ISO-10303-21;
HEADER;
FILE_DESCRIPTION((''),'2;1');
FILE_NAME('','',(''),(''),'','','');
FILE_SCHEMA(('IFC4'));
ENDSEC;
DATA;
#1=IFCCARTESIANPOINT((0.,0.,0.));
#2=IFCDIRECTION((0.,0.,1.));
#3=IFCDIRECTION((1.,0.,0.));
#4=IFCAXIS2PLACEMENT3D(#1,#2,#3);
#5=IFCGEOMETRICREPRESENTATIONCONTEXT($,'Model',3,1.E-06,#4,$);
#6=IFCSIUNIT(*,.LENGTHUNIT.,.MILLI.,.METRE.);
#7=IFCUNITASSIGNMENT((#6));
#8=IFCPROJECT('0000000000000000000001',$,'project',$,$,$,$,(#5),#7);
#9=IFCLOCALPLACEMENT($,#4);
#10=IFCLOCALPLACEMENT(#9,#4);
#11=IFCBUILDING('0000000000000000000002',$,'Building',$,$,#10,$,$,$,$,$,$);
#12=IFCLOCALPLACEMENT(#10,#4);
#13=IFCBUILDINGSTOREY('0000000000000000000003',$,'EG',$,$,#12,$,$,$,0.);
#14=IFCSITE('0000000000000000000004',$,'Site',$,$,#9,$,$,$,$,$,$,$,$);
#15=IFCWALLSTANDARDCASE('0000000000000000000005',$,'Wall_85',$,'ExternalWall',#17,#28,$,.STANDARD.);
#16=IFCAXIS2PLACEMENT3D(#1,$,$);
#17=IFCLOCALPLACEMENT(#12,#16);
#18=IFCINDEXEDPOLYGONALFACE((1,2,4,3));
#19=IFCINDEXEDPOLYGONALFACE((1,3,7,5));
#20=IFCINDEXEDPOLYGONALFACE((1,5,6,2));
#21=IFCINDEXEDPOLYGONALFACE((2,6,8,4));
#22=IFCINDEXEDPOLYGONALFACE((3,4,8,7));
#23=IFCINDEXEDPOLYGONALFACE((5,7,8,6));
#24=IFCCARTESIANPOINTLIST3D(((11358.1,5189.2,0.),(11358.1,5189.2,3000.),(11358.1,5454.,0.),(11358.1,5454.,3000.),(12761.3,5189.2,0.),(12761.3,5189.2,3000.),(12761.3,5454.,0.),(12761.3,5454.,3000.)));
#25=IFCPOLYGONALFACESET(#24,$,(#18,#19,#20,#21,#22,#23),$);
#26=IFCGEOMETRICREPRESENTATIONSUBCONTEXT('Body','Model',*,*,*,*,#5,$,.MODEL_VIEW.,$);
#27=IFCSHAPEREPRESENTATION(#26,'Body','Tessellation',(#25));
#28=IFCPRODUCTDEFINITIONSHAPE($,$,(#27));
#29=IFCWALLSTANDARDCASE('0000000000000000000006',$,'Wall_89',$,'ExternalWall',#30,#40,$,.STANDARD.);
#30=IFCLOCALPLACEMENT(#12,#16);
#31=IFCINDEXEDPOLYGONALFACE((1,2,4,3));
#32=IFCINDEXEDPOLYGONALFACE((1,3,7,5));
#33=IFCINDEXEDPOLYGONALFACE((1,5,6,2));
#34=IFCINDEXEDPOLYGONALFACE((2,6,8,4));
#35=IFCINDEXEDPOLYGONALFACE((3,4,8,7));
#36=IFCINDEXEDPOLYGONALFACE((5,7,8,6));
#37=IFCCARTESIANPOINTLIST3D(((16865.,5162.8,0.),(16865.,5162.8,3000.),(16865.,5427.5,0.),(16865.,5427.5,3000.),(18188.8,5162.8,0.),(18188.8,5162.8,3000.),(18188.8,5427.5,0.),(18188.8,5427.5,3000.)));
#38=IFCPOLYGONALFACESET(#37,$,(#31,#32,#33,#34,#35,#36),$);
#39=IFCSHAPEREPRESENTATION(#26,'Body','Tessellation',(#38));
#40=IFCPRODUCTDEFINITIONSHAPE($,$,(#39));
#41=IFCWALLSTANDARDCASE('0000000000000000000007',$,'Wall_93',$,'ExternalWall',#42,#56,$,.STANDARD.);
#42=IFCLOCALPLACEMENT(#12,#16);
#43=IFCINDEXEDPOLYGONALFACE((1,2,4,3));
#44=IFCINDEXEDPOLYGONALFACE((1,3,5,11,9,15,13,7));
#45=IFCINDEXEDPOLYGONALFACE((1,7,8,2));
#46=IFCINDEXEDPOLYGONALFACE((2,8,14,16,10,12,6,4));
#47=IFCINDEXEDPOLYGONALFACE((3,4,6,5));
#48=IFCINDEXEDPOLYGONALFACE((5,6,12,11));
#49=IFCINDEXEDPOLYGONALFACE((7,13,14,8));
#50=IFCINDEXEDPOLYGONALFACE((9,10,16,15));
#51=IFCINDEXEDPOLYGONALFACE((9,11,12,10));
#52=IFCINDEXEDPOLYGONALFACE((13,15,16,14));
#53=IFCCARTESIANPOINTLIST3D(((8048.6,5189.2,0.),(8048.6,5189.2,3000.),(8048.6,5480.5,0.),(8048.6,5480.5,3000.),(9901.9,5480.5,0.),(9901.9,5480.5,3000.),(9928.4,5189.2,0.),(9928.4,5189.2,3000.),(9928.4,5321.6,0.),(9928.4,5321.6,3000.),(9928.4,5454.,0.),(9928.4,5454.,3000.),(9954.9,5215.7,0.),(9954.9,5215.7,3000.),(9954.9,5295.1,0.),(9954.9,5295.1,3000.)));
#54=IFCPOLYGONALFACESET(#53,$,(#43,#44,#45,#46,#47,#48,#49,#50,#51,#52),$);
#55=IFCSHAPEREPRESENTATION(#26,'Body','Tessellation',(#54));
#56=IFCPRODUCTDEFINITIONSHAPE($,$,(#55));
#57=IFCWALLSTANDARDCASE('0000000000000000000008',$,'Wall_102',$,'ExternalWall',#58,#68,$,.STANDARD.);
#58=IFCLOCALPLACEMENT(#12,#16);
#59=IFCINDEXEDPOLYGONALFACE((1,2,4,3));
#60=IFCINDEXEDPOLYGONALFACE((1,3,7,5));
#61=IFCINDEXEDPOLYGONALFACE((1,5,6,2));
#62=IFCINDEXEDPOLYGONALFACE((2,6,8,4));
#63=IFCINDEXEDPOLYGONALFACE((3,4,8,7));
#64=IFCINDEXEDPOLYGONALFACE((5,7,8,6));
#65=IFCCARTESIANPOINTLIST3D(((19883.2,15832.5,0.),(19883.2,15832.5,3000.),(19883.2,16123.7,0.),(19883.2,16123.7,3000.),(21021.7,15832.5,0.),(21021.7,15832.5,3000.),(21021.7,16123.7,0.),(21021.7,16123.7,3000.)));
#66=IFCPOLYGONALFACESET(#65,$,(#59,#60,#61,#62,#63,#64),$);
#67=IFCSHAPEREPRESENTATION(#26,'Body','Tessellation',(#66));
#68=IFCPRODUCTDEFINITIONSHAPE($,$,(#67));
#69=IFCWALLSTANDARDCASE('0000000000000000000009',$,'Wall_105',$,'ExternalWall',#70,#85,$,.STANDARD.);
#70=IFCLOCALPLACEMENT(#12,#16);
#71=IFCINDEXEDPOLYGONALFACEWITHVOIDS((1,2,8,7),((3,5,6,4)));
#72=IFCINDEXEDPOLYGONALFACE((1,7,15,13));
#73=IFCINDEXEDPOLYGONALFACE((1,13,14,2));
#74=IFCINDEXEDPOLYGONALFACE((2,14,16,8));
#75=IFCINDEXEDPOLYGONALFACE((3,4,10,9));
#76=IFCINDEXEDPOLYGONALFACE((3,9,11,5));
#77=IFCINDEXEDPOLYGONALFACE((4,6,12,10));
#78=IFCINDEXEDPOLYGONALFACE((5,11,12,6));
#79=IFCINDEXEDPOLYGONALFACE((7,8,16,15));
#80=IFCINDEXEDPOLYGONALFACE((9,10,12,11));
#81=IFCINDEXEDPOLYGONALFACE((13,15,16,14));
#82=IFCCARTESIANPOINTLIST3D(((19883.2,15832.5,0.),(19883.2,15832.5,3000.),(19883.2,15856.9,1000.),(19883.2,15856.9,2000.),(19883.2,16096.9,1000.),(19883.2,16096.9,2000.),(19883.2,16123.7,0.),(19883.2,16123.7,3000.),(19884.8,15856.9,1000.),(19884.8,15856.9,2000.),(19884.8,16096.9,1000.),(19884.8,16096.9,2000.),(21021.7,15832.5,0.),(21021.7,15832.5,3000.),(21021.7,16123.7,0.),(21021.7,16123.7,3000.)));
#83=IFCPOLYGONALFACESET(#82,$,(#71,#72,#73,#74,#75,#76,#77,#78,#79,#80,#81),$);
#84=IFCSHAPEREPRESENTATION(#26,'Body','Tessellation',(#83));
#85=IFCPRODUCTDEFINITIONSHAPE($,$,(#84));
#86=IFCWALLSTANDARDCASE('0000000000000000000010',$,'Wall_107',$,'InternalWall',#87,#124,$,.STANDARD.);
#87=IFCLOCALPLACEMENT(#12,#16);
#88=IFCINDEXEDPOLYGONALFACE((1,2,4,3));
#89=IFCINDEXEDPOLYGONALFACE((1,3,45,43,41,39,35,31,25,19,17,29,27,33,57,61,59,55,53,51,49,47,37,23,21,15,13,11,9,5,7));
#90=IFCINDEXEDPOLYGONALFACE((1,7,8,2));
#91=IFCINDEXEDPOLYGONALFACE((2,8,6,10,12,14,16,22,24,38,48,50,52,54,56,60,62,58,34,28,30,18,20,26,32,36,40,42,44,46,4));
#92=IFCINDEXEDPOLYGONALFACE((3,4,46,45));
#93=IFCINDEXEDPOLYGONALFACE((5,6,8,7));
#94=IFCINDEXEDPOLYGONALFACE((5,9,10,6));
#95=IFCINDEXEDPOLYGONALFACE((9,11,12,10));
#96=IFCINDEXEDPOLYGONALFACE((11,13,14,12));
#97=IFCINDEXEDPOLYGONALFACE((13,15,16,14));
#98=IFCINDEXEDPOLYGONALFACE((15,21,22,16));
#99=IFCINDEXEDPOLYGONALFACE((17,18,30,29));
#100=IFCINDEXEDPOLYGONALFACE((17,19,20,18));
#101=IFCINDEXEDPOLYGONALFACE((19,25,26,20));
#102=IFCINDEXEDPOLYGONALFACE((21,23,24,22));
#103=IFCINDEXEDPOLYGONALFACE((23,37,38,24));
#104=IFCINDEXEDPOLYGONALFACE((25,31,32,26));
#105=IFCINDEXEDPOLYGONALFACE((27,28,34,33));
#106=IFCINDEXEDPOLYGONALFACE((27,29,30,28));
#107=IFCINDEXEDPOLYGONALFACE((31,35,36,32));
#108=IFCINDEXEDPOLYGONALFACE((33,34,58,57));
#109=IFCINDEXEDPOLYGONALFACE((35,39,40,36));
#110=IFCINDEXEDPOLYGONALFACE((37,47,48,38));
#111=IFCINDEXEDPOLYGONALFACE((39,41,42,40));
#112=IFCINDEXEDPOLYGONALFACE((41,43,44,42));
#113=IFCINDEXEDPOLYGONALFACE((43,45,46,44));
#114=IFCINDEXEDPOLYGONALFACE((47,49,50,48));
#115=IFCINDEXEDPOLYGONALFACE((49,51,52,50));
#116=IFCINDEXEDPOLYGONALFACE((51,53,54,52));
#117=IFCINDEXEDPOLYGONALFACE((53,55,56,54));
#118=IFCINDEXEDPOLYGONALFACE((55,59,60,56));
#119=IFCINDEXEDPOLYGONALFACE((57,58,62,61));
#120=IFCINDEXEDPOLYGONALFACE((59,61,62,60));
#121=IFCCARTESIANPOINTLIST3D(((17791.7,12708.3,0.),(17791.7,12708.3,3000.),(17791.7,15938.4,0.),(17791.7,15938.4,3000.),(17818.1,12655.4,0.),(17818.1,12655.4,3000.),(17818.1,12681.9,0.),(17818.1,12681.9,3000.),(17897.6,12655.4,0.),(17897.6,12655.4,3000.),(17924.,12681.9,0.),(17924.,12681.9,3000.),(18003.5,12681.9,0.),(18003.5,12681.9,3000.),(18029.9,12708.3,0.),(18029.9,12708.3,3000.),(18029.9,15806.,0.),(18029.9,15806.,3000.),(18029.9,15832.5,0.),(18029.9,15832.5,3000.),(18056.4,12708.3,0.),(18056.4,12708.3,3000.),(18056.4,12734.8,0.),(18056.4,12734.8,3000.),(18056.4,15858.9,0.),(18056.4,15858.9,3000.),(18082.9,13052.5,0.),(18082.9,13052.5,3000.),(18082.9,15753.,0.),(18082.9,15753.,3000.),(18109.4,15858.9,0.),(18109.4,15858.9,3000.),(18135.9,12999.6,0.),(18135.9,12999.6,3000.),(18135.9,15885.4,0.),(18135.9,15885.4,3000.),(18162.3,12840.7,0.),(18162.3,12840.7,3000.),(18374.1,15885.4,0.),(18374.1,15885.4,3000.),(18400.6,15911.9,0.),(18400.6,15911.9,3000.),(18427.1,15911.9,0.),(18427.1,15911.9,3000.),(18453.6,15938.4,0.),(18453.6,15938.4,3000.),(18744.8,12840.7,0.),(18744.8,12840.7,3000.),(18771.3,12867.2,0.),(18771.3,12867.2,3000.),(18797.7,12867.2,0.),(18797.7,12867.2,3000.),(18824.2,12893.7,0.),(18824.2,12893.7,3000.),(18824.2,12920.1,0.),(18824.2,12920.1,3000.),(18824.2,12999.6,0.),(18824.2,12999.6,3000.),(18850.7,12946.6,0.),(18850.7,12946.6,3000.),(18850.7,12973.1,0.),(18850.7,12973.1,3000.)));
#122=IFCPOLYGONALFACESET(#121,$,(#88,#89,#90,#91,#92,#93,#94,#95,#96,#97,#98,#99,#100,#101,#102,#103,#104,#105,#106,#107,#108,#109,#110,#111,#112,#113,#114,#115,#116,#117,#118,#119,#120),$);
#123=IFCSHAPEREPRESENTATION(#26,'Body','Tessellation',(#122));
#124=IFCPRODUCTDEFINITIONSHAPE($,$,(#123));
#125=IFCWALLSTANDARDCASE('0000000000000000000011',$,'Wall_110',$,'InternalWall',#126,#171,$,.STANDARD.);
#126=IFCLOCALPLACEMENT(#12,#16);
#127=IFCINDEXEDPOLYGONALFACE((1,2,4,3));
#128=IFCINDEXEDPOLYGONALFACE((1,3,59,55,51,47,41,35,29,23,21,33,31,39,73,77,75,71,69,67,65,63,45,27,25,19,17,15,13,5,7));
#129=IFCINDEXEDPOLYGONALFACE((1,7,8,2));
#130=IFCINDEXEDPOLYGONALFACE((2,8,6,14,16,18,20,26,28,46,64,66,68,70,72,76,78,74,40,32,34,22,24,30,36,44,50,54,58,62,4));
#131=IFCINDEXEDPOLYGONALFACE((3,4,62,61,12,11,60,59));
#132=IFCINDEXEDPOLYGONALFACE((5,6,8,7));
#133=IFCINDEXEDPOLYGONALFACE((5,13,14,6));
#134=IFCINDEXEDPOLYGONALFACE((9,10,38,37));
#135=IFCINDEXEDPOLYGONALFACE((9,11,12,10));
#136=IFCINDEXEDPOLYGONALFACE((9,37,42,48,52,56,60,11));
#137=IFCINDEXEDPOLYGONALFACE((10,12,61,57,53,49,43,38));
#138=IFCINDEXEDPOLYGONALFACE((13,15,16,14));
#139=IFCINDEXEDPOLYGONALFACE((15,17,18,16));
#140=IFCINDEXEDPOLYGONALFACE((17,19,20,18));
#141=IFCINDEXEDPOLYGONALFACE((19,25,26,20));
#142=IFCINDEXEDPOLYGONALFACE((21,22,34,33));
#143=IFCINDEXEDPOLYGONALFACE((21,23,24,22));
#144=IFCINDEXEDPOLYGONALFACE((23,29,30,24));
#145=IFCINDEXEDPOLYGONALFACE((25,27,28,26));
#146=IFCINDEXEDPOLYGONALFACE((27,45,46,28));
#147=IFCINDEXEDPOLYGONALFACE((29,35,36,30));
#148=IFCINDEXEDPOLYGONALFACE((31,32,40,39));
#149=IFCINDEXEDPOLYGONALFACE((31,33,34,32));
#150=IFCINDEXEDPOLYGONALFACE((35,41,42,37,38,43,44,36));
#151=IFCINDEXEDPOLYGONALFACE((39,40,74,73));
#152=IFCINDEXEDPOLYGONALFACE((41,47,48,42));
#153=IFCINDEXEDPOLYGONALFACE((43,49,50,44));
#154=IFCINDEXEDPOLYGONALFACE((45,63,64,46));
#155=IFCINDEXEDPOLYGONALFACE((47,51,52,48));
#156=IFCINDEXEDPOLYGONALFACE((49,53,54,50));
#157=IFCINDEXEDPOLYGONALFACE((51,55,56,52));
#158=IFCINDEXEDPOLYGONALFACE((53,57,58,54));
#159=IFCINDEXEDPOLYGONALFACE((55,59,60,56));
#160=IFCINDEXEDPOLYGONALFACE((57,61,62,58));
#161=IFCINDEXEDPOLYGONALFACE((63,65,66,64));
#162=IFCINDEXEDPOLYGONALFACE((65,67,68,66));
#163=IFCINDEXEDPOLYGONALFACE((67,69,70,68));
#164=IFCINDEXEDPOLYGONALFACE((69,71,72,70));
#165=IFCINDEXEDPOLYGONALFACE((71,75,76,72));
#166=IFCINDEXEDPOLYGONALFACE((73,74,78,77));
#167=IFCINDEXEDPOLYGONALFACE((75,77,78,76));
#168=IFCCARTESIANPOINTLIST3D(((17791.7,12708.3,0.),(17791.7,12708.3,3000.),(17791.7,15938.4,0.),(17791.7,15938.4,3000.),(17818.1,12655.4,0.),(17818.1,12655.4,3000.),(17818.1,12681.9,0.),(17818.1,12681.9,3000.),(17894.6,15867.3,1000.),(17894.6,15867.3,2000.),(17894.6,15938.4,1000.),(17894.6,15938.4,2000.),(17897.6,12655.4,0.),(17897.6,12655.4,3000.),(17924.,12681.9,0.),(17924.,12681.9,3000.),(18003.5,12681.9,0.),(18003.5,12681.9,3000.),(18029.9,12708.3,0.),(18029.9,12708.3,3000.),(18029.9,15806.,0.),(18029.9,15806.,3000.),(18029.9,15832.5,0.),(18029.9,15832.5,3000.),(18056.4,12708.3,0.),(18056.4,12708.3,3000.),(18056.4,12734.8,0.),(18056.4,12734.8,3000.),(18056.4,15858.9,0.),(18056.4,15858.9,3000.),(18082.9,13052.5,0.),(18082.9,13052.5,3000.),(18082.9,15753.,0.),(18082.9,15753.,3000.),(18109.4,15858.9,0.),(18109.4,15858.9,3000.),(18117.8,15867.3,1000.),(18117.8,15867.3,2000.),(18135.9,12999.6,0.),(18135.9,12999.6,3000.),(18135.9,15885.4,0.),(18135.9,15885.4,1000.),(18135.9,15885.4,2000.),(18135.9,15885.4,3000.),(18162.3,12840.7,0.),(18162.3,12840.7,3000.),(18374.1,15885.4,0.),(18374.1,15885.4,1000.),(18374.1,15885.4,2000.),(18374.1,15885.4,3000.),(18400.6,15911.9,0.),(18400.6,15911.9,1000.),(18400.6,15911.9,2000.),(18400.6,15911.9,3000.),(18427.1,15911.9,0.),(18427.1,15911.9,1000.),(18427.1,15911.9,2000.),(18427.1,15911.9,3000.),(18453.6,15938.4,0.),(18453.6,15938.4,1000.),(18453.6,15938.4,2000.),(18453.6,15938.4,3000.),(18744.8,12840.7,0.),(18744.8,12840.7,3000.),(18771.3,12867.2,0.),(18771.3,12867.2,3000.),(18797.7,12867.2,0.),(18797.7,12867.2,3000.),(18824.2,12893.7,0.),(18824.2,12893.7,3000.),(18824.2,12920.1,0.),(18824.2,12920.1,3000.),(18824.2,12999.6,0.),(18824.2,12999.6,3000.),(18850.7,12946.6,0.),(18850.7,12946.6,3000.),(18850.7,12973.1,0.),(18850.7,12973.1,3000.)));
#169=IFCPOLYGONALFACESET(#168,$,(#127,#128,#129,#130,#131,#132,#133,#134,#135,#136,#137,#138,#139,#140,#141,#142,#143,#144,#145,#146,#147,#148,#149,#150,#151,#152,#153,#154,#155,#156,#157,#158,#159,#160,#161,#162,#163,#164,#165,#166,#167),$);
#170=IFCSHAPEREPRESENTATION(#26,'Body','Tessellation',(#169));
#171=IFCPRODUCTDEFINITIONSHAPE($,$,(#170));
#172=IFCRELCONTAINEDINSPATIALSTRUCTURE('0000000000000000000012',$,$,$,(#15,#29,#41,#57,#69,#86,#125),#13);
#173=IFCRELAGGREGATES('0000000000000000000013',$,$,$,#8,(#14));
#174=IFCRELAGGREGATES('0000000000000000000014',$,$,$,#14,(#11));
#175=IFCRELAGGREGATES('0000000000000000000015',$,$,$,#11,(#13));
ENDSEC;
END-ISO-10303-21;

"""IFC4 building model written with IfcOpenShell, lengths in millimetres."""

from ifc_helpers import new_model, si_unit, frame, origin_with_axes, place, context, subcontext, project, spatial, polyline, rectangle, outline, extrude, element, save


model = new_model("IFC4")

# Units and contexts
model_context = context("Model", 3, precision=1e-06, world=origin_with_axes())
body_context = subcontext(model_context, "Body", "Model", "MODEL_VIEW")
ifc_project = project(units=[si_unit("LENGTHUNIT", "METRE", prefix="MILLI")], contexts=[model_context])

# Site, building, storey
site_placement = place(None, origin_with_axes())
site = spatial("IfcSite", under=ifc_project, at=site_placement, Name="Site")
building_placement = place(site_placement, origin_with_axes())
building = spatial("IfcBuilding", under=site, at=building_placement, Name="Building")
storey_placement = place(building_placement, origin_with_axes())
storey = spatial("IfcBuildingStorey", under=building, at=storey_placement, Name="EG", Elevation=0.0)

# Wall
for number, where, z_axis, x_axis, name in (
    (1, (0.0, 0.0, 0.0), (0.0, 0.0, 1.0), (1.0, 0.0, 0.0), "Wall_85"),
):
    element("IfcWallStandardCase", number, at=place(storey_placement, frame(where, z_axis=z_axis, x_axis=x_axis)), inside=storey, Name=name, ObjectType="ExternalWall", PredefinedType="STANDARD", context=body_context, shape_type="SweptSolid", body=[
        extrude(outline(polyline([(11358.1, 5189.2, 0.0), (11358.1, 5454.0, 0.0), (12761.3, 5454.0, 0.0), (12761.3, 5189.2, 0.0), (11358.1, 5189.2, 0.0)])), origin_with_axes(), (0.0, 0.0, 1.0), 3000.0),
    ])

# Wall
wall_1_placement = place(storey_placement, origin_with_axes())
element("IfcWallStandardCase", 2, at=wall_1_placement, inside=storey, Name="Wall_89", ObjectType="ExternalWall", PredefinedType="STANDARD", context=body_context, shape_type="SweptSolid", body=[
    extrude(outline(polyline([(16865.0, 5162.8, 0.0), (16865.0, 5427.5, 0.0), (18188.8, 5427.5, 0.0), (18188.8, 5162.8, 0.0), (16865.0, 5162.8, 0.0)])), origin_with_axes(), (0.0, 0.0, 1.0), 3000.0),
])

# Wall
for number, where, z_axis, x_axis, name in (
    (3, (0.0, 0.0, 0.0), (0.0, 0.0, 1.0), (1.0, 0.0, 0.0), "Wall_93"),
):
    element("IfcWallStandardCase", number, at=place(storey_placement, frame(where, z_axis=z_axis, x_axis=x_axis)), inside=storey, Name=name, ObjectType="ExternalWall", PredefinedType="STANDARD", context=body_context, shape_type="SweptSolid", body=[
        extrude(outline(polyline([(8048.6, 5189.2, 0.0), (8048.6, 5480.5, 0.0), (9901.9, 5480.5, 0.0), (9928.4, 5454.0, 0.0), (9928.4, 5321.6, 0.0), (9954.9, 5295.1, 0.0), (9954.9, 5215.7, 0.0), (9928.4, 5189.2, 0.0), (8048.6, 5189.2, 0.0)])), origin_with_axes(), (0.0, 0.0, 1.0), 3000.0),
    ])

# Wall
for number, where, z_axis, x_axis, name in (
    (4, (0.0, 0.0, 0.0), (0.0, 0.0, 1.0), (1.0, 0.0, 0.0), "Wall_102"),
):
    element("IfcWallStandardCase", number, at=place(storey_placement, frame(where, z_axis=z_axis, x_axis=x_axis)), inside=storey, Name=name, ObjectType="ExternalWall", PredefinedType="STANDARD", context=body_context, shape_type="SweptSolid", body=[
        extrude(outline(polyline([(19883.2, 15832.5, 0.0), (19883.2, 16123.7, 0.0), (21021.7, 16123.7, 0.0), (21021.7, 15832.5, 0.0), (19883.2, 15832.5, 0.0)])), origin_with_axes(), (0.0, 0.0, 1.0), 3000.0),
    ])

# Wall, opening
wall_2_placement = place(storey_placement, origin_with_axes())
wall_2 = element("IfcWallStandardCase", 5, at=wall_2_placement, inside=storey, Name="Wall_105", ObjectType="ExternalWall", PredefinedType="STANDARD", context=body_context, shape_type="SweptSolid", body=[
    extrude(outline(polyline([(19883.2, 15832.5, 0.0), (19883.2, 16123.7, 0.0), (21021.7, 16123.7, 0.0), (21021.7, 15832.5, 0.0), (19883.2, 15832.5, 0.0)])), origin_with_axes(), (0.0, 0.0, 1.0), 3000.0),
])
opening_1_placement = place(wall_2_placement, origin_with_axes())
element("IfcOpeningElement", 6, at=opening_1_placement, inside=storey, cuts=wall_2, context=body_context, shape_type="SweptSolid", body=[
    extrude(rectangle(XDim=1323.8, YDim=240.0), frame((19222.9, 15976.9, 1000.0), z_axis=(0.0, 0.0, 1.0), x_axis=(1.0, 0.0, 0.0)), (0.0, 0.0, 1.0), 1000.0),
])

# Wall
for number, where, z_axis, x_axis, name in (
    (7, (0.0, 0.0, 0.0), (0.0, 0.0, 1.0), (1.0, 0.0, 0.0), "Wall_107"),
):
    element("IfcWallStandardCase", number, at=place(storey_placement, frame(where, z_axis=z_axis, x_axis=x_axis)), inside=storey, Name=name, ObjectType="InternalWall", PredefinedType="STANDARD", context=body_context, shape_type="SweptSolid", body=[
        extrude(outline(polyline([(17818.1, 12655.4, 0.0), (17818.1, 12681.9, 0.0), (17791.7, 12708.3, 0.0), (17791.7, 15938.4, 0.0), (18453.6, 15938.4, 0.0), (18427.1, 15911.9, 0.0), (18400.6, 15911.9, 0.0), (18374.1, 15885.4, 0.0), (18135.9, 15885.4, 0.0), (18109.4, 15858.9, 0.0), (18056.4, 15858.9, 0.0), (18029.9, 15832.5, 0.0), (18029.9, 15806.0, 0.0), (18082.9, 15753.0, 0.0), (18082.9, 13052.5, 0.0), (18135.9, 12999.6, 0.0), (18824.2, 12999.6, 0.0), (18850.7, 12973.1, 0.0), (18850.7, 12946.6, 0.0), (18824.2, 12920.1, 0.0), (18824.2, 12893.7, 0.0), (18797.7, 12867.2, 0.0), (18771.3, 12867.2, 0.0), (18744.8, 12840.7, 0.0), (18162.3, 12840.7, 0.0), (18056.4, 12734.8, 0.0), (18056.4, 12708.3, 0.0), (18029.9, 12708.3, 0.0), (18003.5, 12681.9, 0.0), (17924.0, 12681.9, 0.0), (17897.6, 12655.4, 0.0), (17818.1, 12655.4, 0.0)])), origin_with_axes(), (0.0, 0.0, 1.0), 3000.0),
    ])

# Wall, opening
wall_3_placement = place(storey_placement, origin_with_axes())
wall_3 = element("IfcWallStandardCase", 8, at=wall_3_placement, inside=storey, Name="Wall_110", ObjectType="InternalWall", PredefinedType="STANDARD", context=body_context, shape_type="SweptSolid", body=[
    extrude(outline(polyline([(17818.1, 12655.4, 0.0), (17818.1, 12681.9, 0.0), (17791.7, 12708.3, 0.0), (17791.7, 15938.4, 0.0), (18453.6, 15938.4, 0.0), (18427.1, 15911.9, 0.0), (18400.6, 15911.9, 0.0), (18374.1, 15885.4, 0.0), (18135.9, 15885.4, 0.0), (18109.4, 15858.9, 0.0), (18056.4, 15858.9, 0.0), (18029.9, 15832.5, 0.0), (18029.9, 15806.0, 0.0), (18082.9, 15753.0, 0.0), (18082.9, 13052.5, 0.0), (18135.9, 12999.6, 0.0), (18824.2, 12999.6, 0.0), (18850.7, 12973.1, 0.0), (18850.7, 12946.6, 0.0), (18824.2, 12920.1, 0.0), (18824.2, 12893.7, 0.0), (18797.7, 12867.2, 0.0), (18771.3, 12867.2, 0.0), (18744.8, 12840.7, 0.0), (18162.3, 12840.7, 0.0), (18056.4, 12734.8, 0.0), (18056.4, 12708.3, 0.0), (18029.9, 12708.3, 0.0), (18003.5, 12681.9, 0.0), (17924.0, 12681.9, 0.0), (17897.6, 12655.4, 0.0), (17818.1, 12655.4, 0.0)])), origin_with_axes(), (0.0, 0.0, 1.0), 3000.0),
])
opening_2_placement = place(wall_3_placement, origin_with_axes())
element("IfcOpeningElement", 9, at=opening_2_placement, inside=storey, cuts=wall_3, context=body_context, shape_type="SweptSolid", body=[
    extrude(rectangle(XDim=1985.7, YDim=115.0), frame((18887.5, 15924.8, 1000.0), z_axis=(0.0, 0.0, 1.0), x_axis=(1.0, 0.0, 0.0)), (0.0, 0.0, 1.0), 1000.0),
])

save(model, "model.ifc")
